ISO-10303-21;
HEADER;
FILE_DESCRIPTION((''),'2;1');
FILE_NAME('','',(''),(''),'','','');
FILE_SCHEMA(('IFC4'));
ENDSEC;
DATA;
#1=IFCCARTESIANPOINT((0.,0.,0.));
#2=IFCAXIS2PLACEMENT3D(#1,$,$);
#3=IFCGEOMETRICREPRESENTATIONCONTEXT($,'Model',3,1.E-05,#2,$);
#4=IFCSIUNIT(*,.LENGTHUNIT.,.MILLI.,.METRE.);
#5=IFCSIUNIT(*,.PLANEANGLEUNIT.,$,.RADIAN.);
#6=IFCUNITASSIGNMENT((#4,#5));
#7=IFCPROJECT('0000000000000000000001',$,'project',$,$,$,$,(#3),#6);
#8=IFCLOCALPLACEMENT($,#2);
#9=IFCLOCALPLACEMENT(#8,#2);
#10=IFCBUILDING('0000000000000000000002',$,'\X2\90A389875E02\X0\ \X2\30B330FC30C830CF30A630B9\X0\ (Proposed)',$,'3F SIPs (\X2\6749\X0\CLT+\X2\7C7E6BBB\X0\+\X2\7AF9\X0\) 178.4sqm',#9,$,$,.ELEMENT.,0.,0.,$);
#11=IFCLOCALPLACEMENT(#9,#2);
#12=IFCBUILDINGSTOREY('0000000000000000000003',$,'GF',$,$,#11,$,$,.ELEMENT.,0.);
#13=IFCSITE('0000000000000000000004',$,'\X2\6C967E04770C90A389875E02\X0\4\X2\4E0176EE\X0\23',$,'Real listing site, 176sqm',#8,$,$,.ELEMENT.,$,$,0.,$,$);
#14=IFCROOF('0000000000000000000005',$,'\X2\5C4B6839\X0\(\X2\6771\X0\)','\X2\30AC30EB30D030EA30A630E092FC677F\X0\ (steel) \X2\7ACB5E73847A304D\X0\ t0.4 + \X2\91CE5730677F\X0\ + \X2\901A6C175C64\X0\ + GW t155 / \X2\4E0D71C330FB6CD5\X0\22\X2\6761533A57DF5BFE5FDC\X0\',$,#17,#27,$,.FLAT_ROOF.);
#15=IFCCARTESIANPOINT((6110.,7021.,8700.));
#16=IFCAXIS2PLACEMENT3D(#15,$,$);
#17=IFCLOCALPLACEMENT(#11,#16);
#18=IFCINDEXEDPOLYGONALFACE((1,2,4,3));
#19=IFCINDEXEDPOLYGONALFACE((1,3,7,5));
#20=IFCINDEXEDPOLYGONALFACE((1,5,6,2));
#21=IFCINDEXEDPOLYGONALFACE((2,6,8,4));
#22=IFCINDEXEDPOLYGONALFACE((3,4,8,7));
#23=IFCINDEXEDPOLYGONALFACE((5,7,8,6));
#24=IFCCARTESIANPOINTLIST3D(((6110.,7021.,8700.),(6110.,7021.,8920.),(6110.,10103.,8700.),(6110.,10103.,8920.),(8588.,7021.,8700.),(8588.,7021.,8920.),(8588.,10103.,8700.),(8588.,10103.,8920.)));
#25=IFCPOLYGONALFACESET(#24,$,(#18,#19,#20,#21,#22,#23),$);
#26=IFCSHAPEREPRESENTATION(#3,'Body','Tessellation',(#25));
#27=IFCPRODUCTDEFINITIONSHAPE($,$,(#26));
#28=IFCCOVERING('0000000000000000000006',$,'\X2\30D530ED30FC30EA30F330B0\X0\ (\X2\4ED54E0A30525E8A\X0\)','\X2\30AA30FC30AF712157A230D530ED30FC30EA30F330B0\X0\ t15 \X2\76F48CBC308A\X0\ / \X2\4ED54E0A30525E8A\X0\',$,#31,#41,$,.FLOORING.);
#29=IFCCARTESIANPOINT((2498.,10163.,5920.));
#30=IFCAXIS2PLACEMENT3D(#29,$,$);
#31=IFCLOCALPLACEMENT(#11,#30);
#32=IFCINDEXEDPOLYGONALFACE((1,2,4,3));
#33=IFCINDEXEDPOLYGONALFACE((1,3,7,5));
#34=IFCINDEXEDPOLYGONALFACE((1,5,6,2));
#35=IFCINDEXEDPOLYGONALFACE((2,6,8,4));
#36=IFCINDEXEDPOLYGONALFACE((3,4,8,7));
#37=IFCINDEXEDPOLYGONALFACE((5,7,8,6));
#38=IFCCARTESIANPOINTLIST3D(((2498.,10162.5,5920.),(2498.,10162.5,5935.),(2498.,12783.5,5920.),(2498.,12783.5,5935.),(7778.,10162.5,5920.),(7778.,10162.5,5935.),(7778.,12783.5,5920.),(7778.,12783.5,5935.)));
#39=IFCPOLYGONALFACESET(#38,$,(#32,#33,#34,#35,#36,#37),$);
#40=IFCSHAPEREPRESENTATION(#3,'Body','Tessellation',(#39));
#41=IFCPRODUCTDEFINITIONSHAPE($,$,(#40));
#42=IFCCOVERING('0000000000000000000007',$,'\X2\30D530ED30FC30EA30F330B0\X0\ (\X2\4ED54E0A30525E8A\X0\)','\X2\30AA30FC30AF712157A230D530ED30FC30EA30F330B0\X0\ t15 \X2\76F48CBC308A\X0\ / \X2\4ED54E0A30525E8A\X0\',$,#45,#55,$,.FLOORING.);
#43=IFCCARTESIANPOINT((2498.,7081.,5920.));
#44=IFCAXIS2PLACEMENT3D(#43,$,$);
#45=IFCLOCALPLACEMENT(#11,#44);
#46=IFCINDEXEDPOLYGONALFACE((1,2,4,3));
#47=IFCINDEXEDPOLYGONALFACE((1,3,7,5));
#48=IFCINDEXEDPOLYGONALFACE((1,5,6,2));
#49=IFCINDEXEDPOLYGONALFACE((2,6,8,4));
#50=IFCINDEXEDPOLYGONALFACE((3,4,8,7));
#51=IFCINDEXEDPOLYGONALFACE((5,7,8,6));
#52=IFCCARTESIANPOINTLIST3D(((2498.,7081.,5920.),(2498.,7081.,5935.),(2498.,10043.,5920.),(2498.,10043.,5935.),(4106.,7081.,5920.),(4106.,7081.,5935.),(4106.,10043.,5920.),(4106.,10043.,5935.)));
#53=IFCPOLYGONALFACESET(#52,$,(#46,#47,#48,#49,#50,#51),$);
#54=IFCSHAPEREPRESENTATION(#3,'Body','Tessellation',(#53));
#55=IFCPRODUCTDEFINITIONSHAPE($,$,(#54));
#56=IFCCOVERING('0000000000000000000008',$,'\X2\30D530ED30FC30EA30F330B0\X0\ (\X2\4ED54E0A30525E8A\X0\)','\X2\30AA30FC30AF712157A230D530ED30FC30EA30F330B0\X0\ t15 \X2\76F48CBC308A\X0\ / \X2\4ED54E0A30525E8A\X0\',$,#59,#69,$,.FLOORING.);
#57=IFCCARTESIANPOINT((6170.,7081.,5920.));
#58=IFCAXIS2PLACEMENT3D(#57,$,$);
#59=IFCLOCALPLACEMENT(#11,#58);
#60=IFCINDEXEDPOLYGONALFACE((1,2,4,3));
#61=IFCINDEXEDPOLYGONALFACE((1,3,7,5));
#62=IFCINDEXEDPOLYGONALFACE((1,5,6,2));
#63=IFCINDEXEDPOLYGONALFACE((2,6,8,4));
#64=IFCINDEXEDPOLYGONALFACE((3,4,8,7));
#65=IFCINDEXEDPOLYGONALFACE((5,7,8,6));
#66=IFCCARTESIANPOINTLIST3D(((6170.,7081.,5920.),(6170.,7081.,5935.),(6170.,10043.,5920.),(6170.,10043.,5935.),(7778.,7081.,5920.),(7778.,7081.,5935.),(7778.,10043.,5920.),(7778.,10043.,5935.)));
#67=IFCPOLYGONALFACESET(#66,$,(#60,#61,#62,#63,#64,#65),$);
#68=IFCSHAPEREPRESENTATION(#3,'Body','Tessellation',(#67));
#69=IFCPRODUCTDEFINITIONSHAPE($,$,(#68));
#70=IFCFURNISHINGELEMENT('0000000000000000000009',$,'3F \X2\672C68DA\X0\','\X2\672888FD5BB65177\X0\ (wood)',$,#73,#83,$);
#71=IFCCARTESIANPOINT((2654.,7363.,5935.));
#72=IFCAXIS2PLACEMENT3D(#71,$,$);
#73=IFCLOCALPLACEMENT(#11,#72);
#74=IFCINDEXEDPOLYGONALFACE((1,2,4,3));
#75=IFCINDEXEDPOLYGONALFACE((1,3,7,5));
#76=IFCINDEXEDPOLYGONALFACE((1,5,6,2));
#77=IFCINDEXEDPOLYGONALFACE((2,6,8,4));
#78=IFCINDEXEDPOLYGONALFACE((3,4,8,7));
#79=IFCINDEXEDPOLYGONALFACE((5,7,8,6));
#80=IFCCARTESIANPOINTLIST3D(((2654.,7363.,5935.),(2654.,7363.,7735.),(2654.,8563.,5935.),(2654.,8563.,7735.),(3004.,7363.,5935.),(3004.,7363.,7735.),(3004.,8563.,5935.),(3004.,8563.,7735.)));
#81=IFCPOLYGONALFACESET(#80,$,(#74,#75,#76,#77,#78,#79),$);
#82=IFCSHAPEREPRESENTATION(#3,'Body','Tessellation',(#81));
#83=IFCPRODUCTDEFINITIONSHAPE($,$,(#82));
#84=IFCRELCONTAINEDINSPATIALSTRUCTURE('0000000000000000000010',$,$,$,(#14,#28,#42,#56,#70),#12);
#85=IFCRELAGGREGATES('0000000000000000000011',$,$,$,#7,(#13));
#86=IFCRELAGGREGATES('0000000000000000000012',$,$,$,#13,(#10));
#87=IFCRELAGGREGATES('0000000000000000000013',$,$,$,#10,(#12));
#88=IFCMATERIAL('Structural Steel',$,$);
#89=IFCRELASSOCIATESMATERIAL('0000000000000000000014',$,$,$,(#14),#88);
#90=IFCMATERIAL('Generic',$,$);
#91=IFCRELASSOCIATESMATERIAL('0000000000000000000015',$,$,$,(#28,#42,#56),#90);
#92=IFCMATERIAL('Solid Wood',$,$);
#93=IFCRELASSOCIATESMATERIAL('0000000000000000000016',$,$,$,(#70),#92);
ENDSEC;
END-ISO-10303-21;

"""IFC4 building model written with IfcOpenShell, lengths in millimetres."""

from ifc_helpers import new_model, si_unit, frame, frame_2d, origin, place, context, project, spatial, rectangle, extrude, material, element, save


model = new_model("IFC4")

# Units and contexts
model_context = context("Model", 3, precision=1e-05, world=origin())
ifc_project = project(units=[si_unit("LENGTHUNIT", "METRE", prefix="MILLI"), si_unit("PLANEANGLEUNIT", "RADIAN")], contexts=[model_context])

# Site, building, storey
site_placement = place(None, origin())
site = spatial("IfcSite", under=ifc_project, at=site_placement, Name="沖縄県那覇市4丁目23", ObjectType="Real listing site, 176sqm", CompositionType="ELEMENT", RefElevation=0.0)
building_placement = place(site_placement, origin())
building = spatial("IfcBuilding", under=site, at=building_placement, Name="那覇市 コートハウス (Proposed)", ObjectType="3F SIPs (杉CLT+籾殻+竹) 178.4sqm", CompositionType="ELEMENT", ElevationOfRefHeight=0.0, ElevationOfTerrain=0.0)
storey_placement = place(building_placement, origin())
storey = spatial("IfcBuildingStorey", under=building, at=storey_placement, Name="GF", CompositionType="ELEMENT", Elevation=0.0)

# Shared definitions
ifc_material_1 = material(Name="Solid Wood")

# Shared definitions
ifc_material_2 = material(Name="Generic")

# Roof
ifc_material_3 = material(Name="Structural Steel")
roof_1_placement = place(storey_placement, frame((6110.0, 7021.0, 8700.0)))
element("IfcRoof", 1, at=roof_1_placement, inside=storey, material=ifc_material_3, Name="屋根(東)", Description="ガルバリウム鋼板 (steel) 立平葺き t0.4 + 野地板 + 通気層 + GW t155 / 不燃・法22条区域対応", PredefinedType="FLAT_ROOF", context=model_context, shape_type="SweptSolid", body=[
    extrude(rectangle(XDim=2478.0, YDim=3082.0, at=frame_2d((1239.0, 1541.0))), frame((6110.0, 7021.0, 8700.0)), (0.0, 0.0, 1.0), 220.0),
])

# Coverings
covering_1_placement = place(storey_placement, frame((2498.0, 10163.0, 5920.0)))
element("IfcCovering", 2, at=covering_1_placement, inside=storey, material=ifc_material_2, Name="フローリング (仕上げ床)", Description="オーク無垢フローリング t15 直貼り / 仕上げ床", PredefinedType="FLOORING", context=model_context, shape_type="SweptSolid", body=[
    extrude(rectangle(XDim=5280.0, YDim=2621.0, at=frame_2d((2640.0, 1310.0))), frame((2498.0, 10163.0, 5920.0)), (0.0, 0.0, 1.0), 15.0),
])
covering_2_placement = place(storey_placement, frame((2498.0, 7081.0, 5920.0)))
element("IfcCovering", 3, at=covering_2_placement, inside=storey, material=ifc_material_2, Name="フローリング (仕上げ床)", Description="オーク無垢フローリング t15 直貼り / 仕上げ床", PredefinedType="FLOORING", context=model_context, shape_type="SweptSolid", body=[
    extrude(rectangle(XDim=1608.0, YDim=2962.0, at=frame_2d((804.0, 1481.0))), frame((2498.0, 7081.0, 5920.0)), (0.0, 0.0, 1.0), 15.0),
])
covering_3_placement = place(storey_placement, frame((6170.0, 7081.0, 5920.0)))
element("IfcCovering", 4, at=covering_3_placement, inside=storey, material=ifc_material_2, Name="フローリング (仕上げ床)", Description="オーク無垢フローリング t15 直貼り / 仕上げ床", PredefinedType="FLOORING", context=model_context, shape_type="SweptSolid", body=[
    extrude(rectangle(XDim=1608.0, YDim=2962.0, at=frame_2d((804.0, 1481.0))), frame((6170.0, 7081.0, 5920.0)), (0.0, 0.0, 1.0), 15.0),
])

# Furnishing element
furnishing_placement = place(storey_placement, frame((2654.0, 7363.0, 5935.0)))
element("IfcFurnishingElement", 5, at=furnishing_placement, inside=storey, material=ifc_material_1, Name="3F 本棚", Description="木製家具 (wood)", context=model_context, shape_type="SweptSolid", body=[
    extrude(rectangle(XDim=350.0, YDim=1200.0, at=frame_2d((175.0, 600.0))), frame((2654.0, 7363.0, 5935.0)), (0.0, 0.0, 1.0), 1800.0),
])

save(model, "model.ifc")
